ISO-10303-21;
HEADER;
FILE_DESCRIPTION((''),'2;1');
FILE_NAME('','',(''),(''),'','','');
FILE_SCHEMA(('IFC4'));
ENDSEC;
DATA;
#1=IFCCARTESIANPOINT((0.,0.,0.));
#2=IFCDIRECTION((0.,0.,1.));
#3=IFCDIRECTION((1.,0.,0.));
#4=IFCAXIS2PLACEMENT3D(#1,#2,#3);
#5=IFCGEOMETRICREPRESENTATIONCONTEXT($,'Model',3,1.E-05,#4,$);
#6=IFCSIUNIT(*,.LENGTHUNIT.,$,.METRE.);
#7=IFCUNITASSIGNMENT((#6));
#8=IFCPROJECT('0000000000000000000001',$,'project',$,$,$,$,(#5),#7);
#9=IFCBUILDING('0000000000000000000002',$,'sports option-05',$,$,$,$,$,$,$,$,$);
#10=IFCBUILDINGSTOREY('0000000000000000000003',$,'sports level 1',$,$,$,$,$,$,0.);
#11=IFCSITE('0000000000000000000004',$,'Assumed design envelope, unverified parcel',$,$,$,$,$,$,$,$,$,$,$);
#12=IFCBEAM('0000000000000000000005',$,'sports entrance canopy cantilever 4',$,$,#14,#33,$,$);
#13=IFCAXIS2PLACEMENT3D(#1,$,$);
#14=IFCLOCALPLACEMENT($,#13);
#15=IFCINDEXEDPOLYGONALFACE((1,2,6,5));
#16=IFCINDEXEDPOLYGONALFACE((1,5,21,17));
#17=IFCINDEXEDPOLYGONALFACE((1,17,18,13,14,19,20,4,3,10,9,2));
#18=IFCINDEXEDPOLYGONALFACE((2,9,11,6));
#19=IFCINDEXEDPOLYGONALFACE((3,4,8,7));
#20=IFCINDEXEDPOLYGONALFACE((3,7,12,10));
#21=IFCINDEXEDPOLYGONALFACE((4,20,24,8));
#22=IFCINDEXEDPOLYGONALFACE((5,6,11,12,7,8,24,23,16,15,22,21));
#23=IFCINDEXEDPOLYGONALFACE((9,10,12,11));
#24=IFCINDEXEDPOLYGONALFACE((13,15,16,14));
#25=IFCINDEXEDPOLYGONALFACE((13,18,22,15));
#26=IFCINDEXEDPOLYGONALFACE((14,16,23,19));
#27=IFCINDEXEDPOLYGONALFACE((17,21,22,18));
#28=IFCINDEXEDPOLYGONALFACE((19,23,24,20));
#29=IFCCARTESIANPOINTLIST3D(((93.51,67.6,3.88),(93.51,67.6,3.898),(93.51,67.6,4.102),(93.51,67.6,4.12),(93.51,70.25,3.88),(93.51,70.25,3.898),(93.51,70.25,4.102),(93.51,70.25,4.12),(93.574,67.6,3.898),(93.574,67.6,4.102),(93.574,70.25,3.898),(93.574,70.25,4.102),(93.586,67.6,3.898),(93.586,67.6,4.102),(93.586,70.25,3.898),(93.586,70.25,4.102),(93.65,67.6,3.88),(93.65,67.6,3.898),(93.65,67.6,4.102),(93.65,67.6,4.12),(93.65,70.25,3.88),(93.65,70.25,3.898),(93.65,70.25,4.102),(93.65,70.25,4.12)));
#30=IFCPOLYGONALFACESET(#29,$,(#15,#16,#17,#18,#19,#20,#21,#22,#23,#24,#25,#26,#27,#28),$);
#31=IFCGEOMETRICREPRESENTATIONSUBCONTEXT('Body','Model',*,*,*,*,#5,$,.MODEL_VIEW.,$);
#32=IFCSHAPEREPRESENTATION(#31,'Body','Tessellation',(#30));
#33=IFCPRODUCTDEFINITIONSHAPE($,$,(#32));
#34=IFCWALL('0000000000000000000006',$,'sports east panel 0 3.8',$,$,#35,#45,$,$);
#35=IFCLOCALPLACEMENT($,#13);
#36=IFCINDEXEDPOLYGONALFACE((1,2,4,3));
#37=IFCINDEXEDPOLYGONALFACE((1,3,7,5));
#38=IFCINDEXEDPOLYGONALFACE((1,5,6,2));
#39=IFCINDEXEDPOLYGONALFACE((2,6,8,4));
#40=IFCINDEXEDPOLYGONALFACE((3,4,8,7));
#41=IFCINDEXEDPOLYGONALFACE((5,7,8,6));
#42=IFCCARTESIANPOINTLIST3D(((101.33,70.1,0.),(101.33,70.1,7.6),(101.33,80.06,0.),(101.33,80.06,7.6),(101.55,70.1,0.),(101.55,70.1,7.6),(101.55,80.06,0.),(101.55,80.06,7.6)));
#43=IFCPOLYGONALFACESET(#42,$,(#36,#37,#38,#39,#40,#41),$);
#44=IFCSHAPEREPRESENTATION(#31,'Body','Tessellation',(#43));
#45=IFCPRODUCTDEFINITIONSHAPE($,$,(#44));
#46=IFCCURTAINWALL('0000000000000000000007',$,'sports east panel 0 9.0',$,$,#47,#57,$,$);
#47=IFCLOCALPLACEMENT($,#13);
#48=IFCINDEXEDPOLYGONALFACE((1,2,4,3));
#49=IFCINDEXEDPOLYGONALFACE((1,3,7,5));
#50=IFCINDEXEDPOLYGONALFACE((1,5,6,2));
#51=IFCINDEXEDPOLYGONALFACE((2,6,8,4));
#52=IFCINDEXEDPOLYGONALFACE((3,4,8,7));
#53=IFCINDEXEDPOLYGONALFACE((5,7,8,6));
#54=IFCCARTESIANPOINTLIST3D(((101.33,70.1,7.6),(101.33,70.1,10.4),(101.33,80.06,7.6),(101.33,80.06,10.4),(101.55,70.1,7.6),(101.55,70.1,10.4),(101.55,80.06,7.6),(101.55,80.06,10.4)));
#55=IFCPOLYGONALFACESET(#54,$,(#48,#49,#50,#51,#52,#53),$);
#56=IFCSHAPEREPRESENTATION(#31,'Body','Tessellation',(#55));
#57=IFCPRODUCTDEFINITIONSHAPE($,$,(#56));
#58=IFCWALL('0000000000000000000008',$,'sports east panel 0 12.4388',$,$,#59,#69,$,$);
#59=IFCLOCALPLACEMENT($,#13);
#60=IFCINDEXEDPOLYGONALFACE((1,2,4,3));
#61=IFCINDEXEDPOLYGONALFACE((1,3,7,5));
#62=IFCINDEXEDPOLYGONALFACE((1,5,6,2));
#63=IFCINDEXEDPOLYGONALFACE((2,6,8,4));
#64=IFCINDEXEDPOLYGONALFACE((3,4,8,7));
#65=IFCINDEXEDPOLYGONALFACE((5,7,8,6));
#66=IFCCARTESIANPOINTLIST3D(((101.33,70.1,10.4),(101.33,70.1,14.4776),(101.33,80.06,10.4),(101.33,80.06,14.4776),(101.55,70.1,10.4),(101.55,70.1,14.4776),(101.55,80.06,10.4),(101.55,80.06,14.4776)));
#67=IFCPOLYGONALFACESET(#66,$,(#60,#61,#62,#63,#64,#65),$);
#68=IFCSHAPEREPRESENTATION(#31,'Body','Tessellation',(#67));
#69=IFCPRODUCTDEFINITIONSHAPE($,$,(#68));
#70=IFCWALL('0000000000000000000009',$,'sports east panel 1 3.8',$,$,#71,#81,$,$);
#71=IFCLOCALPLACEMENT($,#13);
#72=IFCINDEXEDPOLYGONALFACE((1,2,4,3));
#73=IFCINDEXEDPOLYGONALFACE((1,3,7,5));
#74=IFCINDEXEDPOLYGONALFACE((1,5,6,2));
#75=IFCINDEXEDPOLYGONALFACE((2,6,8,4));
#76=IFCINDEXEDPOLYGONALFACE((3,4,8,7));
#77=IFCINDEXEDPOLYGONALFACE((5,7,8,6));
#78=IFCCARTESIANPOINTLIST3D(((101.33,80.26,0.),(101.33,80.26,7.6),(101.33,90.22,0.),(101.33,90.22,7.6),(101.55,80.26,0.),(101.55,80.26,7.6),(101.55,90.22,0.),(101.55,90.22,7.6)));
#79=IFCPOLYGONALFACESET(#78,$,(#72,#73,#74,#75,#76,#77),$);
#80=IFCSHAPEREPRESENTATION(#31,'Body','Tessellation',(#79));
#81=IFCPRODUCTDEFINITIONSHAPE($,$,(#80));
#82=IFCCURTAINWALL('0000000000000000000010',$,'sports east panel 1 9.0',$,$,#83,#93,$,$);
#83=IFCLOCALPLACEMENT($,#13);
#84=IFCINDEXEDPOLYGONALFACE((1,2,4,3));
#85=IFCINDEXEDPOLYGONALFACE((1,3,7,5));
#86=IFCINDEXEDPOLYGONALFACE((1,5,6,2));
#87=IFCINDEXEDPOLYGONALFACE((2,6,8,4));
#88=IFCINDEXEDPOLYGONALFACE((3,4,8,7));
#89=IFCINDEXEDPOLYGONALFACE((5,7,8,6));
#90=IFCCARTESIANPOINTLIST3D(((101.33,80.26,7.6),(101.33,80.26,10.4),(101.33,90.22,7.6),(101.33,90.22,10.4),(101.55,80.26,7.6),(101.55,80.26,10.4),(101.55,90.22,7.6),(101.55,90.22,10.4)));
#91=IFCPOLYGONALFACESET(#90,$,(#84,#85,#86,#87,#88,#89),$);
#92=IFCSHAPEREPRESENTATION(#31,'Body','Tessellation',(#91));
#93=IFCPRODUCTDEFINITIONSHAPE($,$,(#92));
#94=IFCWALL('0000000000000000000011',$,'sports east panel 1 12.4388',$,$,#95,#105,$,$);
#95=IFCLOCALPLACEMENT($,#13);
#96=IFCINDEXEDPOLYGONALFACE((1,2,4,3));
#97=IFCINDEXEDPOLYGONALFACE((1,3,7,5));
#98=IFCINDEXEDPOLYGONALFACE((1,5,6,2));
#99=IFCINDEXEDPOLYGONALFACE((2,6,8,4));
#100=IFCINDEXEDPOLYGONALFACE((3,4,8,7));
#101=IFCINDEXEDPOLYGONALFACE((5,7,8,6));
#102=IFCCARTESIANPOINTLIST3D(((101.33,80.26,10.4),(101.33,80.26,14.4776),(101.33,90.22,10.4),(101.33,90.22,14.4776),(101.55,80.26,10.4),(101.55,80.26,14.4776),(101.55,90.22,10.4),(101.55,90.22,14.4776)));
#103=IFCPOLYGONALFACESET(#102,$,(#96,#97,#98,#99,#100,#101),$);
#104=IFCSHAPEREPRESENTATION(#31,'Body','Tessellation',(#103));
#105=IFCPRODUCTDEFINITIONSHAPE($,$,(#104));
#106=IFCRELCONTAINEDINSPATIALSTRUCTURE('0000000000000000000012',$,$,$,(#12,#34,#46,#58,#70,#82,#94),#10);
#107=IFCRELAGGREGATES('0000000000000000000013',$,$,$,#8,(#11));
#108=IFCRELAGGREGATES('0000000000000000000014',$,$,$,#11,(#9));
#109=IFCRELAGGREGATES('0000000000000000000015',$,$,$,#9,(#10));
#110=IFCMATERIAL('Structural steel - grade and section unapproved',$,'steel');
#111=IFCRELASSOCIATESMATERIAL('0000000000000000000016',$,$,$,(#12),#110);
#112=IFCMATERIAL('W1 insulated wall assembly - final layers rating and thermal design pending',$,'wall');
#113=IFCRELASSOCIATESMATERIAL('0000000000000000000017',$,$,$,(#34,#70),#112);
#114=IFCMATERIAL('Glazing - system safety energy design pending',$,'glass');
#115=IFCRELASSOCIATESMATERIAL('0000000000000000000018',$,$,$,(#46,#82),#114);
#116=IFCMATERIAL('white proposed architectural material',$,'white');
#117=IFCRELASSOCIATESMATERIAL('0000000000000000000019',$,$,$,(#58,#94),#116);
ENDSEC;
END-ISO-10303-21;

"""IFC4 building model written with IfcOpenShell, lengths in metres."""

from ifc_helpers import new_model, si_unit, frame, origin_with_axes, place, context, subcontext, project, spatial, rectangle, i_section, extrude, material, element, save


model = new_model("IFC4")

# Units and contexts
model_context = context("Model", 3, precision=1e-05, world=origin_with_axes())
body_context = subcontext(model_context, "Body", "Model", "MODEL_VIEW")
ifc_project = project(units=[si_unit("LENGTHUNIT", "METRE")], contexts=[model_context])

# Site, building, storey
site = spatial("IfcSite", under=ifc_project, Name="Assumed design envelope, unverified parcel")
building = spatial("IfcBuilding", under=site, Name="sports option-05")
storey = spatial("IfcBuildingStorey", under=building, Name="sports level 1", Elevation=0.0)

# Shared definitions
ifc_material_1 = material(Name="Structural steel - grade and section unapproved", Category="steel")

# Beam
beam_1_placement = place(None, frame((93.58, 70.25, 4.0), z_axis=(0.0, -1.0, 0.0), x_axis=(1.0, 0.0, 0.0)))
element("IfcBeam", 1, at=beam_1_placement, inside=storey, material=ifc_material_1, Name="sports entrance canopy cantilever 4", context=body_context, shape_type="SweptSolid", body=[
    extrude(i_section(OverallWidth=0.14, OverallDepth=0.24, WebThickness=0.012, FlangeThickness=0.018, FilletRadius=0.0), origin_with_axes(), (0.0, 0.0, 1.0), 2.65),
])

# Wall
ifc_material_2 = material(Name="W1 insulated wall assembly - final layers rating and thermal design pending", Category="wall")
wall_1_placement = place(None, frame((101.44, 75.08, 0.0), z_axis=(0.0, 0.0, 1.0), x_axis=(1.0, 0.0, 0.0)))
element("IfcWall", 2, at=wall_1_placement, inside=storey, material=ifc_material_2, Name="sports east panel 0 3.8", context=body_context, shape_type="SweptSolid", body=[
    extrude(rectangle(XDim=0.22, YDim=9.96), origin_with_axes(), (0.0, 0.0, 1.0), 7.6),
])

# Curtain wall
ifc_material_3 = material(Name="Glazing - system safety energy design pending", Category="glass")
curtain_wall_1_placement = place(None, frame((101.44, 75.08, 7.6), z_axis=(0.0, 0.0, 1.0), x_axis=(1.0, 0.0, 0.0)))
element("IfcCurtainWall", 3, at=curtain_wall_1_placement, inside=storey, material=ifc_material_3, Name="sports east panel 0 9.0", context=body_context, shape_type="SweptSolid", body=[
    extrude(rectangle(XDim=0.22, YDim=9.96), origin_with_axes(), (0.0, 0.0, 1.0), 2.8),
])

# Walls
ifc_material_4 = material(Name="white proposed architectural material", Category="white")
wall_2_placement = place(None, frame((101.44, 75.08, 10.4), z_axis=(0.0, 0.0, 1.0), x_axis=(1.0, 0.0, 0.0)))
element("IfcWall", 4, at=wall_2_placement, inside=storey, material=ifc_material_4, Name="sports east panel 0 12.4388", context=body_context, shape_type="SweptSolid", body=[
    extrude(rectangle(XDim=0.22, YDim=9.96), origin_with_axes(), (0.0, 0.0, 1.0), 4.0776),
])
wall_3_placement = place(None, frame((101.44, 85.24, 0.0), z_axis=(0.0, 0.0, 1.0), x_axis=(1.0, 0.0, 0.0)))
element("IfcWall", 5, at=wall_3_placement, inside=storey, material=ifc_material_2, Name="sports east panel 1 3.8", context=body_context, shape_type="SweptSolid", body=[
    extrude(rectangle(XDim=0.22, YDim=9.96), origin_with_axes(), (0.0, 0.0, 1.0), 7.6),
])

# Curtain wall
curtain_wall_2_placement = place(None, frame((101.44, 85.24, 7.6), z_axis=(0.0, 0.0, 1.0), x_axis=(1.0, 0.0, 0.0)))
element("IfcCurtainWall", 6, at=curtain_wall_2_placement, inside=storey, material=ifc_material_3, Name="sports east panel 1 9.0", context=body_context, shape_type="SweptSolid", body=[
    extrude(rectangle(XDim=0.22, YDim=9.96), origin_with_axes(), (0.0, 0.0, 1.0), 2.8),
])

# Wall
wall_4_placement = place(None, frame((101.44, 85.24, 10.4), z_axis=(0.0, 0.0, 1.0), x_axis=(1.0, 0.0, 0.0)))
element("IfcWall", 7, at=wall_4_placement, inside=storey, material=ifc_material_4, Name="sports east panel 1 12.4388", context=body_context, shape_type="SweptSolid", body=[
    extrude(rectangle(XDim=0.22, YDim=9.96), origin_with_axes(), (0.0, 0.0, 1.0), 4.0776),
])

save(model, "model.ifc")
